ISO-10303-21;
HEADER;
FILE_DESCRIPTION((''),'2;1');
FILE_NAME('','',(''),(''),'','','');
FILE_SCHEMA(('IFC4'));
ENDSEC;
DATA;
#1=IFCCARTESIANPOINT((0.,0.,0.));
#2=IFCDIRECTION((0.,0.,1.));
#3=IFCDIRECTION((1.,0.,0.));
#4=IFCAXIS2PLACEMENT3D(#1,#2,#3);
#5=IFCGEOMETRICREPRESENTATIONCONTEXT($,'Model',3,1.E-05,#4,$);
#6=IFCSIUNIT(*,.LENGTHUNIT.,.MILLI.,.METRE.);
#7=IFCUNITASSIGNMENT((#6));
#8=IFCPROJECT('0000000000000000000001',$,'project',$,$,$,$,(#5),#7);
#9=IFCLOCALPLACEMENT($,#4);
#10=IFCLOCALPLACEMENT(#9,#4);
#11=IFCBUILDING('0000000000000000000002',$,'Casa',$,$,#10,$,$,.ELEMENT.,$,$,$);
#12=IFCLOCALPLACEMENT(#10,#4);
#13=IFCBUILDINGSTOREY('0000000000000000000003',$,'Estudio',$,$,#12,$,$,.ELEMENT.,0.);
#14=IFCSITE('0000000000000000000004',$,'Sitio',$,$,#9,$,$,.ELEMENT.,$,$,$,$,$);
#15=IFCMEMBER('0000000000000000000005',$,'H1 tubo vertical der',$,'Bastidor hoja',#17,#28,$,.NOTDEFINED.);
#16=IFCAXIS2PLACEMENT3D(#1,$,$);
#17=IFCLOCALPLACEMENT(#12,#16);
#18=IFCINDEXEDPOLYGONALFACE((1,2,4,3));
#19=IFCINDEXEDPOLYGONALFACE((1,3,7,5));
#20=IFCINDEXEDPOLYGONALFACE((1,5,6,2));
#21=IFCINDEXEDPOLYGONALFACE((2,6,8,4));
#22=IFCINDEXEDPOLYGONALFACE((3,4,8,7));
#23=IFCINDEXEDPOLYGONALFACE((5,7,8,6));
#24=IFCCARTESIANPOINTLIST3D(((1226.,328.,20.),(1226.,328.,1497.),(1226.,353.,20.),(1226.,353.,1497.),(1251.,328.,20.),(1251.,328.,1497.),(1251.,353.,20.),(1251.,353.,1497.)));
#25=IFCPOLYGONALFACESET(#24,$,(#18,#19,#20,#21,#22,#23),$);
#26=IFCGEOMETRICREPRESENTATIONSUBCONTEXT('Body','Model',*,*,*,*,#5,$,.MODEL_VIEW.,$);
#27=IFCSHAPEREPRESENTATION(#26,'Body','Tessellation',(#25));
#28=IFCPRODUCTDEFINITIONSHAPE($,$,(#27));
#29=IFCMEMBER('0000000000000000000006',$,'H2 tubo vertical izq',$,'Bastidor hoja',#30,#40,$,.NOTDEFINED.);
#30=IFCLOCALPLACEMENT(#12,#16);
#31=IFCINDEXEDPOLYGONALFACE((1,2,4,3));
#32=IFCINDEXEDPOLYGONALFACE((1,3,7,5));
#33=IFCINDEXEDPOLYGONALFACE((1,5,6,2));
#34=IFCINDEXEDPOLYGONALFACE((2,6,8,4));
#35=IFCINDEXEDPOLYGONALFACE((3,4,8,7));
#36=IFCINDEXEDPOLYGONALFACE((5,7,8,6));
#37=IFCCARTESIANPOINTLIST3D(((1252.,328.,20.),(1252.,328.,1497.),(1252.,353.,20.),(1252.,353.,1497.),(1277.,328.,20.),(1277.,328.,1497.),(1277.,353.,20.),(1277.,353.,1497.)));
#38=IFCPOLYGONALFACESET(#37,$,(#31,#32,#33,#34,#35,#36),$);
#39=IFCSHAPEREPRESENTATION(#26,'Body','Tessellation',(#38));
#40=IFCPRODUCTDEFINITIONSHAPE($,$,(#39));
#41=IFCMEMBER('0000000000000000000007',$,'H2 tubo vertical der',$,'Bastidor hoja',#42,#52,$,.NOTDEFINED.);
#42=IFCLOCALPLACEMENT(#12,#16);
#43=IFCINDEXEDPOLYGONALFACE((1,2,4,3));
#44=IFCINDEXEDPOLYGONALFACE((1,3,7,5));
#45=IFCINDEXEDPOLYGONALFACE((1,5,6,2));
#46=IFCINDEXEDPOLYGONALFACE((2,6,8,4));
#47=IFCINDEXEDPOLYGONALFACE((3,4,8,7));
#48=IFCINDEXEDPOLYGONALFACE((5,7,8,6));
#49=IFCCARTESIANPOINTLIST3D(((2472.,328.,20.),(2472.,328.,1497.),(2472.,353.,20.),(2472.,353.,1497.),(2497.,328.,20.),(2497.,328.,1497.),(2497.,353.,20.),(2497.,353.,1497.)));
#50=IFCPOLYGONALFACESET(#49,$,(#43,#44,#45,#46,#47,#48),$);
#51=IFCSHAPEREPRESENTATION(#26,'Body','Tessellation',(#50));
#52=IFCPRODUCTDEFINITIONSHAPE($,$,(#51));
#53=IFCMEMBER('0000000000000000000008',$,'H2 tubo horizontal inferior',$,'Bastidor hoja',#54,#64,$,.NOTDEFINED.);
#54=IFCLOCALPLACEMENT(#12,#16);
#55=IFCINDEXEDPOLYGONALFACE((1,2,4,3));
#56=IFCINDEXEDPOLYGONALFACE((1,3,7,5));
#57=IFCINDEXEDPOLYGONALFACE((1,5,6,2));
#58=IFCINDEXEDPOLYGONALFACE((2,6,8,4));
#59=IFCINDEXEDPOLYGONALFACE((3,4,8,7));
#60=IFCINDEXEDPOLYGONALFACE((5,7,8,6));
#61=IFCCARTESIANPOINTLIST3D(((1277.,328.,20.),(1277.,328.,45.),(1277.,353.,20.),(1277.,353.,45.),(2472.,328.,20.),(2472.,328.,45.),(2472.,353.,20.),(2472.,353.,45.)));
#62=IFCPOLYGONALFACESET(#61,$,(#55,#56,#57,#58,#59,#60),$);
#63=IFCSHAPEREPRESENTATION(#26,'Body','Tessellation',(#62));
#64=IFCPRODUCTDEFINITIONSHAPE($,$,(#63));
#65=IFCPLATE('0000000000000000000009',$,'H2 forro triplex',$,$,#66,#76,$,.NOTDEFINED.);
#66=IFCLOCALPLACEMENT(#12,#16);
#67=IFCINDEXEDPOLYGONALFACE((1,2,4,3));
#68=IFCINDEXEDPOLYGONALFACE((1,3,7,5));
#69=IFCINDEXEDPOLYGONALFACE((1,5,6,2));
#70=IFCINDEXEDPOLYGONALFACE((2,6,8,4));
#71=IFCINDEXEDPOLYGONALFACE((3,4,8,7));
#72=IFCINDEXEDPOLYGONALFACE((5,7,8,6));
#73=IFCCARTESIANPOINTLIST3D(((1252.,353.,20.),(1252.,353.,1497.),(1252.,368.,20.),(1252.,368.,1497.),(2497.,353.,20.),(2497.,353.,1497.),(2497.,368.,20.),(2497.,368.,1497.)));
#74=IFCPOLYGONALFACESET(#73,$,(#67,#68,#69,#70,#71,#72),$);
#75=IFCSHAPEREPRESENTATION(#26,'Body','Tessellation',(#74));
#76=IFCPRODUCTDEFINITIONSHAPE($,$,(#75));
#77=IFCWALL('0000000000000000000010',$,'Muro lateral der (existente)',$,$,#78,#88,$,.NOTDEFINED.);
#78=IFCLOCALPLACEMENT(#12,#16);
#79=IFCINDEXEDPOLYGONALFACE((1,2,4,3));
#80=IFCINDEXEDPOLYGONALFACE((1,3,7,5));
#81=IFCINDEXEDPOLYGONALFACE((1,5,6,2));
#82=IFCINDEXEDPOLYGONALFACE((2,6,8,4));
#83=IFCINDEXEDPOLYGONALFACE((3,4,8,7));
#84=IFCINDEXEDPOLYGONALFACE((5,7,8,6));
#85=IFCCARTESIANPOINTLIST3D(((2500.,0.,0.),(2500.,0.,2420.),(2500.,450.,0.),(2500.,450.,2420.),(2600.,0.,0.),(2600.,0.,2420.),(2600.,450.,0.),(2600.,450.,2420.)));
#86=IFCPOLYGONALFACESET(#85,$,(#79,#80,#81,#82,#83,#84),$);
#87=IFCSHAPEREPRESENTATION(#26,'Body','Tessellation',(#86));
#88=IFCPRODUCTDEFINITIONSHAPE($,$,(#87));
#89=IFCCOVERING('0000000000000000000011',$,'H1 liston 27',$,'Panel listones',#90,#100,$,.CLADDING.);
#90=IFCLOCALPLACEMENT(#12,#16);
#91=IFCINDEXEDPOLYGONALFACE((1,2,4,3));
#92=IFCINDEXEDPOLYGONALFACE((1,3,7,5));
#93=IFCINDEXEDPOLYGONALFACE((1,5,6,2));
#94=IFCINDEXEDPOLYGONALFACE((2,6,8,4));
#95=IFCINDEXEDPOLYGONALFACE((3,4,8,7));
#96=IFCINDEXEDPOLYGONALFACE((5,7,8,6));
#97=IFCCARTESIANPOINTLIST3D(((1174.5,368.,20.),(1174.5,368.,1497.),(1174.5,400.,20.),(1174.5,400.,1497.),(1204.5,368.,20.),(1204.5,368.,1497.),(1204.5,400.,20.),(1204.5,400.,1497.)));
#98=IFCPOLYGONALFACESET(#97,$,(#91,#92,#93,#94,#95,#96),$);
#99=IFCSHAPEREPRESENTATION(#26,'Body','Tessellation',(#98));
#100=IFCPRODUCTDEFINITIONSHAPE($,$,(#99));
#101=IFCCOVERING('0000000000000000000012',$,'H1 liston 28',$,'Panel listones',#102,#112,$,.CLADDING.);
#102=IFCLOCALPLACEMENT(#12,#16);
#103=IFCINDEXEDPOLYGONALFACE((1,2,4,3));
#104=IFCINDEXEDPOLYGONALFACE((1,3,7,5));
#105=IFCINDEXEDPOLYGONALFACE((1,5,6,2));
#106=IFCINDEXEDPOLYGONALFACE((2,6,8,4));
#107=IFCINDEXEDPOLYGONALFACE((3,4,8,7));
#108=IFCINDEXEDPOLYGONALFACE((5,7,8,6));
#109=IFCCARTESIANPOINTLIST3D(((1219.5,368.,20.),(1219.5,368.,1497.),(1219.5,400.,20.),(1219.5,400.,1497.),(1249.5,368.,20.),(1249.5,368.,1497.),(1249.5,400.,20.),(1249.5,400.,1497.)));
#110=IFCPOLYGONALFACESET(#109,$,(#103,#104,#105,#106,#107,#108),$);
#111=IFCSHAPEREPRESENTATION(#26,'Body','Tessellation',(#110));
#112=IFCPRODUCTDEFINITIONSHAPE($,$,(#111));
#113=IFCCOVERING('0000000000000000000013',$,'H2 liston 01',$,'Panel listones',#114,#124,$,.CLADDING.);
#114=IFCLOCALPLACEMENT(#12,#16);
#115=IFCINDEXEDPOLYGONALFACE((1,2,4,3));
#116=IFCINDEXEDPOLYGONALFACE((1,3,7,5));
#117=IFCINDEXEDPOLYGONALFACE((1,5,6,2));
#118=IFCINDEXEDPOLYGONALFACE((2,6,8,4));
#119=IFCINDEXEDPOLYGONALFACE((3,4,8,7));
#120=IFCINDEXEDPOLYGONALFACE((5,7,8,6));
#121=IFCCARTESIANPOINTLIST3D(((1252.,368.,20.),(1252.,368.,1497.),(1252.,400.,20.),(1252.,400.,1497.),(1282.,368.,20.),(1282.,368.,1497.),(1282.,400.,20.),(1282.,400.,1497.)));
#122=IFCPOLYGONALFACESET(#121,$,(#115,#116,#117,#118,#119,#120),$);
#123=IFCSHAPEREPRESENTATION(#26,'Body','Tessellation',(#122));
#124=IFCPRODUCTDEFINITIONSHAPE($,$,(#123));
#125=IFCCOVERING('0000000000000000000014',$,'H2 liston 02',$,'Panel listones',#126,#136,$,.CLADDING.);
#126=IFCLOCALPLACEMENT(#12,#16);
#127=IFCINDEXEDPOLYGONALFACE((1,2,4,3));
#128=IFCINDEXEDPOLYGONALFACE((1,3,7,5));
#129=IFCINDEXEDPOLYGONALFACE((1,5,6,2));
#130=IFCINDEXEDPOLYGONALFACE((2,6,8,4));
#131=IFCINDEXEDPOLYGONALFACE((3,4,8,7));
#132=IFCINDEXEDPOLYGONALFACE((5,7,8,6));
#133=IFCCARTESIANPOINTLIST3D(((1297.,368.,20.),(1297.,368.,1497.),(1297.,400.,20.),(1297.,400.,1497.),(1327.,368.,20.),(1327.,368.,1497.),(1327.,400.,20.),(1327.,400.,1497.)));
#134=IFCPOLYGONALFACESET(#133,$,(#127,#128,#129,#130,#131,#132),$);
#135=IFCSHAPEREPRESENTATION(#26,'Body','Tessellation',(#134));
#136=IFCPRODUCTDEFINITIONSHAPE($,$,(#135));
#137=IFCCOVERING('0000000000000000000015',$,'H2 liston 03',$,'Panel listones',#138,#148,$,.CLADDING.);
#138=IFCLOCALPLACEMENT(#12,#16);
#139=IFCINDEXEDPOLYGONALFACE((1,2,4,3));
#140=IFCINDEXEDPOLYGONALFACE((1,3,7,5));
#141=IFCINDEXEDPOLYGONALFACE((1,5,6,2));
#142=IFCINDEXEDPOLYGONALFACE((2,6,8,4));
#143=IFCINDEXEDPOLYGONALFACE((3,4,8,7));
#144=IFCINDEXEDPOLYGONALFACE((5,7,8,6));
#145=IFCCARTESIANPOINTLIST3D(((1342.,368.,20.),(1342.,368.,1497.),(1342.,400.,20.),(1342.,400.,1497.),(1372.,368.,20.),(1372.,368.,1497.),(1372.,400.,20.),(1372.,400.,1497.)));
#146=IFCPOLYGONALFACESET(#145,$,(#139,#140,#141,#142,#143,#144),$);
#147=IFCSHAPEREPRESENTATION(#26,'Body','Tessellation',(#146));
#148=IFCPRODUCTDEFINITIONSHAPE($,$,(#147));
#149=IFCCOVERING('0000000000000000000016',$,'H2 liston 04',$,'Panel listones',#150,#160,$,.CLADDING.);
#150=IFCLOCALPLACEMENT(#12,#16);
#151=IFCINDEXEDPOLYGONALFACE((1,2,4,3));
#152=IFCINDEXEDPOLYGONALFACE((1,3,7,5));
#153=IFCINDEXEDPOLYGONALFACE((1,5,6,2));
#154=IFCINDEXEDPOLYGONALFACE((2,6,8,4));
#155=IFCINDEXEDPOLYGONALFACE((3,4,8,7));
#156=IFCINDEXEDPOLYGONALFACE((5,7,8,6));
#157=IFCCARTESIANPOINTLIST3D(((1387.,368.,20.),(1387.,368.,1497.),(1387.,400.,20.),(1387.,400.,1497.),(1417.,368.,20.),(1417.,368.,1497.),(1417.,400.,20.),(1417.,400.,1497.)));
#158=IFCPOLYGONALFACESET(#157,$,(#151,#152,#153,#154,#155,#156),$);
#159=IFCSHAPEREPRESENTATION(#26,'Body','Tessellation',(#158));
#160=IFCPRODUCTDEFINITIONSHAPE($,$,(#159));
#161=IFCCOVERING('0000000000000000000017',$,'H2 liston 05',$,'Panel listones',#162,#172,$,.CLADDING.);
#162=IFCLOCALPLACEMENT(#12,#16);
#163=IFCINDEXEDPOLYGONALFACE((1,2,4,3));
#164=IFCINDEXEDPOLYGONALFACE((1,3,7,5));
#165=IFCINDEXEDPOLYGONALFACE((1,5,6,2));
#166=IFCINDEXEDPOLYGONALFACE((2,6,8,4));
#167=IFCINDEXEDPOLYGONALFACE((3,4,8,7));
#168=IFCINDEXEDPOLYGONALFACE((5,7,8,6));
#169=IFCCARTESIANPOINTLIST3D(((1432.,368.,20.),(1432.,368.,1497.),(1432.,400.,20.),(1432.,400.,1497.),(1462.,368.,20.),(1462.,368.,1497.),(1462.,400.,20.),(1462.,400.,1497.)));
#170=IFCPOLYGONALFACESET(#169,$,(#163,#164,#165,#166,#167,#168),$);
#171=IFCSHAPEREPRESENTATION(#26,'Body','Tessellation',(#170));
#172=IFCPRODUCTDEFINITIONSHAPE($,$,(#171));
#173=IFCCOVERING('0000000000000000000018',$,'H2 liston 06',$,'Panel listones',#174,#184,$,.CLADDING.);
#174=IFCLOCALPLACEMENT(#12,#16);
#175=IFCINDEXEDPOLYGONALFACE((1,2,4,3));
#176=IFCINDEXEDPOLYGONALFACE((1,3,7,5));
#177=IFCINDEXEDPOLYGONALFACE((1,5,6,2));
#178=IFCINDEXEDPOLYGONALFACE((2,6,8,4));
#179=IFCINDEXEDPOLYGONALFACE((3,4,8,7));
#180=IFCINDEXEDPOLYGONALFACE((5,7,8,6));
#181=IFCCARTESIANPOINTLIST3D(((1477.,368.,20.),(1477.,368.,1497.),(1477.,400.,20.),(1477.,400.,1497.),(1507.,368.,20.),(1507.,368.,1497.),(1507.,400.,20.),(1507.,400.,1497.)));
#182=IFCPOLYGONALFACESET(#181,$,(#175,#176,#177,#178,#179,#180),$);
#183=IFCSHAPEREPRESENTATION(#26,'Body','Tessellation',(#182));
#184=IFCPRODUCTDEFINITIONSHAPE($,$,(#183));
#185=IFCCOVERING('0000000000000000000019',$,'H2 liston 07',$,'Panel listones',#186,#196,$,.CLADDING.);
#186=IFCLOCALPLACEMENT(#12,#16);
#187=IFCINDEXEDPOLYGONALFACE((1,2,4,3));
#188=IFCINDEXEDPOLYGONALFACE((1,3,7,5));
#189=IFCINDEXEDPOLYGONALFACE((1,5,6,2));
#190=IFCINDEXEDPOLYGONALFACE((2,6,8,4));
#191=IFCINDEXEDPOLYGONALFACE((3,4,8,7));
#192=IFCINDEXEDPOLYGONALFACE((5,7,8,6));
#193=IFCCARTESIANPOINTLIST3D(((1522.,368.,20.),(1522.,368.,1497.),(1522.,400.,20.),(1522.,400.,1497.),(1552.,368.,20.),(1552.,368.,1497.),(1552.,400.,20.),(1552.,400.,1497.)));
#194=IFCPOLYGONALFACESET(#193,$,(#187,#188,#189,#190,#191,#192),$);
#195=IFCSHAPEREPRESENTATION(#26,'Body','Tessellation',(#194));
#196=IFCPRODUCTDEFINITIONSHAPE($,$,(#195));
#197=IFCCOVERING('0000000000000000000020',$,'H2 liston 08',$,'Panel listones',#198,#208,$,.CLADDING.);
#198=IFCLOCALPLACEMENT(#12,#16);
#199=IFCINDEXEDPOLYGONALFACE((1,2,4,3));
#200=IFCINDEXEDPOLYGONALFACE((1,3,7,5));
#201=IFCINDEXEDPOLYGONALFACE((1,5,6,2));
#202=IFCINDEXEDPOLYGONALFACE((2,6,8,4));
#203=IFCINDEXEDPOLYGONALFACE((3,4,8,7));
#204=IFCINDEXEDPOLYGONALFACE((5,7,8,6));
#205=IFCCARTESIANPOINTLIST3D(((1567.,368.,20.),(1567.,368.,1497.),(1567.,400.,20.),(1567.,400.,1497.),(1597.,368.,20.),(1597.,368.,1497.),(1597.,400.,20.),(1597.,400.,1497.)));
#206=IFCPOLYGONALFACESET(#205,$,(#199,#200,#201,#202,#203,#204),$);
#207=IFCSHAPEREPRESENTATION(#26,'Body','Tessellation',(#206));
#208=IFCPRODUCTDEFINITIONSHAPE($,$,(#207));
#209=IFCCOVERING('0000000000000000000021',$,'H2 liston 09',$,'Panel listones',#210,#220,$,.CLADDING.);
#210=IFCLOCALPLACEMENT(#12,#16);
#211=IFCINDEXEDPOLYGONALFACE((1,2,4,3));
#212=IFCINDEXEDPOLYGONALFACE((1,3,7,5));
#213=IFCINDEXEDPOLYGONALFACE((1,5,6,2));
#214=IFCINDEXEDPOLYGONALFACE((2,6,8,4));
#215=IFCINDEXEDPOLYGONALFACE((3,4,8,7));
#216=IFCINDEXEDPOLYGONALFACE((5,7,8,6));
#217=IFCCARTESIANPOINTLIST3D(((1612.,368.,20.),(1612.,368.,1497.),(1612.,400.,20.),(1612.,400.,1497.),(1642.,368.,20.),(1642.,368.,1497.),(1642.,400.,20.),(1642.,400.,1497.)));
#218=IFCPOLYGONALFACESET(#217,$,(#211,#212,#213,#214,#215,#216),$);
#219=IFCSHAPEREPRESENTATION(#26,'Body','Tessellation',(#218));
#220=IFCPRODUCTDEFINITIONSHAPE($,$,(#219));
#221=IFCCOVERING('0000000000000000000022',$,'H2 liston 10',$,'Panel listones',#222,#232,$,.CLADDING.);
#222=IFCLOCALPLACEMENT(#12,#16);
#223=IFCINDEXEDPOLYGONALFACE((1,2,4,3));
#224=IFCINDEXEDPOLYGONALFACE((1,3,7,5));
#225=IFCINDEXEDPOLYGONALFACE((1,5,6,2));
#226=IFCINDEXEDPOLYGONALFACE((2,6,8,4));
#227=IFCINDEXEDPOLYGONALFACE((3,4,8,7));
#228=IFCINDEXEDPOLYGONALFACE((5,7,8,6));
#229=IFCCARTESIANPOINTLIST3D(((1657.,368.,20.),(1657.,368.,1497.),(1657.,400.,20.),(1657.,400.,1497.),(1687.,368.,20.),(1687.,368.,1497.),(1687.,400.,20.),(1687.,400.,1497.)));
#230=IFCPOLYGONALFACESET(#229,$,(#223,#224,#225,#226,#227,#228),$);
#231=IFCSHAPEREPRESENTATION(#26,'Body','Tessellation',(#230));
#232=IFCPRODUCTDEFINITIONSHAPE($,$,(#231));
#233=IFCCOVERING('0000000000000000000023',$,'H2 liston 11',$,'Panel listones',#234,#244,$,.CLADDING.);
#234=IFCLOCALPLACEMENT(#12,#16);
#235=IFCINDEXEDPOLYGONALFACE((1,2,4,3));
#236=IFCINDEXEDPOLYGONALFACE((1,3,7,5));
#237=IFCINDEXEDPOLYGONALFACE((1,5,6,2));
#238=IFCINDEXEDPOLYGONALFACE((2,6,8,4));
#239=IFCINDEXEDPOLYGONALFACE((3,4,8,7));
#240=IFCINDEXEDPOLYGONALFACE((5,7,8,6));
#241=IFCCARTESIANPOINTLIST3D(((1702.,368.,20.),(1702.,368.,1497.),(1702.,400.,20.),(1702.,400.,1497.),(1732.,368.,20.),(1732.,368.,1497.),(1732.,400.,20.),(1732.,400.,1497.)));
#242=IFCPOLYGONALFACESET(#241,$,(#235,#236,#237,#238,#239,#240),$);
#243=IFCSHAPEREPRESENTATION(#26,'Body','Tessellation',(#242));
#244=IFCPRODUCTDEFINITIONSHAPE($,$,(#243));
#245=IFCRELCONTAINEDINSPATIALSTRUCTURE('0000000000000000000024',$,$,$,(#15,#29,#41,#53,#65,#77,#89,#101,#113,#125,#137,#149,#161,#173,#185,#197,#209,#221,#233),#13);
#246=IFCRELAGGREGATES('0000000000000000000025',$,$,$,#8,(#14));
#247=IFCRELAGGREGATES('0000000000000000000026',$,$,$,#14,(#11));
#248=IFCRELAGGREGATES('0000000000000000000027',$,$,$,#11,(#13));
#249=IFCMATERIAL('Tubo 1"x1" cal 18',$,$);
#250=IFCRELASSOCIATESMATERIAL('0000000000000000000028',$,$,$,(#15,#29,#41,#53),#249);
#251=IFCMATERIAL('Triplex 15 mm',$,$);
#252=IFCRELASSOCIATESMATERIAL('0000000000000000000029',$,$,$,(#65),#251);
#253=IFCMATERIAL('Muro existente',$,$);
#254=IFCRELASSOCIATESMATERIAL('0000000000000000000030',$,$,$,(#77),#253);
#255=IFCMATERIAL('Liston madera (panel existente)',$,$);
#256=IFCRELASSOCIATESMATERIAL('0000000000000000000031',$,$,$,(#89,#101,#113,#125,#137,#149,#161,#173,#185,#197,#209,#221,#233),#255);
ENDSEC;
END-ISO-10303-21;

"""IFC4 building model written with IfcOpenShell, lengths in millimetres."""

from ifc_helpers import new_model, si_unit, frame, frame_2d, origin_with_axes, place, context, subcontext, project, spatial, rectangle, extrude, material, element, save


model = new_model("IFC4")

# Units and contexts
model_context = context("Model", 3, precision=1e-05, world=origin_with_axes())
body_context = subcontext(model_context, "Body", "Model", "MODEL_VIEW")
ifc_project = project(units=[si_unit("LENGTHUNIT", "METRE", prefix="MILLI")], contexts=[model_context])

# Site, building, storey
site_placement = place(None, origin_with_axes())
site = spatial("IfcSite", under=ifc_project, at=site_placement, Name="Sitio", CompositionType="ELEMENT")
building_placement = place(site_placement, origin_with_axes())
building = spatial("IfcBuilding", under=site, at=building_placement, Name="Casa", CompositionType="ELEMENT")
storey_placement = place(building_placement, origin_with_axes())
storey = spatial("IfcBuildingStorey", under=building, at=storey_placement, Name="Estudio", CompositionType="ELEMENT", Elevation=0.0)

# Members
ifc_material_1 = material(Name="Tubo 1\"x1\" cal 18")
for number, where, z_axis, x_axis, name in (
    (1, (1226.0, 328.0, 20.0), (0.0, 0.0, 1.0), (1.0, 0.0, 0.0), "H1 tubo vertical der"),
    (2, (1252.0, 328.0, 20.0), (0.0, 0.0, 1.0), (1.0, 0.0, 0.0), "H2 tubo vertical izq"),
    (3, (2472.0, 328.0, 20.0), (0.0, 0.0, 1.0), (1.0, 0.0, 0.0), "H2 tubo vertical der"),
):
    element("IfcMember", number, at=place(storey_placement, frame(where, z_axis=z_axis, x_axis=x_axis)), inside=storey, material=ifc_material_1, Name=name, ObjectType="Bastidor hoja", PredefinedType="NOTDEFINED", context=body_context, shape_type="SweptSolid", body=[
        extrude(rectangle(XDim=25.0, YDim=25.0, at=frame_2d((12.5, 12.5))), origin_with_axes(), (0.0, 0.0, 1.0), 1477.0),
    ])
member_placement = place(storey_placement, frame((1277.0, 328.0, 20.0), z_axis=(0.0, 0.0, 1.0), x_axis=(1.0, 0.0, 0.0)))
element("IfcMember", 4, at=member_placement, inside=storey, material=ifc_material_1, Name="H2 tubo horizontal inferior", ObjectType="Bastidor hoja", PredefinedType="NOTDEFINED", context=body_context, shape_type="SweptSolid", body=[
    extrude(rectangle(XDim=1195.0, YDim=25.0, at=frame_2d((597.5, 12.5))), origin_with_axes(), (0.0, 0.0, 1.0), 25.0),
])

# Plate
ifc_material_2 = material(Name="Triplex 15 mm")
plate_placement = place(storey_placement, frame((1252.0, 353.0, 20.0), z_axis=(0.0, 0.0, 1.0), x_axis=(1.0, 0.0, 0.0)))
element("IfcPlate", 5, at=plate_placement, inside=storey, material=ifc_material_2, Name="H2 forro triplex", PredefinedType="NOTDEFINED", context=body_context, shape_type="SweptSolid", body=[
    extrude(rectangle(XDim=1245.0, YDim=15.0, at=frame_2d((622.5, 7.5))), origin_with_axes(), (0.0, 0.0, 1.0), 1477.0),
])

# Wall
ifc_material_3 = material(Name="Muro existente")
wall_placement = place(storey_placement, frame((2500.0, 0.0, 0.0), z_axis=(0.0, 0.0, 1.0), x_axis=(1.0, 0.0, 0.0)))
element("IfcWall", 6, at=wall_placement, inside=storey, material=ifc_material_3, Name="Muro lateral der (existente)", PredefinedType="NOTDEFINED", context=body_context, shape_type="SweptSolid", body=[
    extrude(rectangle(XDim=100.0, YDim=450.0, at=frame_2d((50.0, 225.0))), origin_with_axes(), (0.0, 0.0, 1.0), 2420.0),
])

# Coverings
ifc_material_4 = material(Name="Liston madera (panel existente)")
for number, where, z_axis, x_axis, name in (
    (7, (1174.5, 368.0, 20.0), (0.0, 0.0, 1.0), (1.0, 0.0, 0.0), "H1 liston 27"),
    (8, (1219.5, 368.0, 20.0), (0.0, 0.0, 1.0), (1.0, 0.0, 0.0), "H1 liston 28"),
    (9, (1252.0, 368.0, 20.0), (0.0, 0.0, 1.0), (1.0, 0.0, 0.0), "H2 liston 01"),
    (10, (1297.0, 368.0, 20.0), (0.0, 0.0, 1.0), (1.0, 0.0, 0.0), "H2 liston 02"),
    (11, (1342.0, 368.0, 20.0), (0.0, 0.0, 1.0), (1.0, 0.0, 0.0), "H2 liston 03"),
    (12, (1387.0, 368.0, 20.0), (0.0, 0.0, 1.0), (1.0, 0.0, 0.0), "H2 liston 04"),
    (13, (1432.0, 368.0, 20.0), (0.0, 0.0, 1.0), (1.0, 0.0, 0.0), "H2 liston 05"),
    (14, (1477.0, 368.0, 20.0), (0.0, 0.0, 1.0), (1.0, 0.0, 0.0), "H2 liston 06"),
    (15, (1522.0, 368.0, 20.0), (0.0, 0.0, 1.0), (1.0, 0.0, 0.0), "H2 liston 07"),
    (16, (1567.0, 368.0, 20.0), (0.0, 0.0, 1.0), (1.0, 0.0, 0.0), "H2 liston 08"),
    (17, (1612.0, 368.0, 20.0), (0.0, 0.0, 1.0), (1.0, 0.0, 0.0), "H2 liston 09"),
    (18, (1657.0, 368.0, 20.0), (0.0, 0.0, 1.0), (1.0, 0.0, 0.0), "H2 liston 10"),
    (19, (1702.0, 368.0, 20.0), (0.0, 0.0, 1.0), (1.0, 0.0, 0.0), "H2 liston 11"),
):
    element("IfcCovering", number, at=place(storey_placement, frame(where, z_axis=z_axis, x_axis=x_axis)), inside=storey, material=ifc_material_4, Name=name, ObjectType="Panel listones", PredefinedType="CLADDING", context=body_context, shape_type="SweptSolid", body=[
        extrude(rectangle(XDim=30.0, YDim=32.0, at=frame_2d((15.0, 16.0))), origin_with_axes(), (0.0, 0.0, 1.0), 1477.0),
    ])

save(model, "model.ifc")
